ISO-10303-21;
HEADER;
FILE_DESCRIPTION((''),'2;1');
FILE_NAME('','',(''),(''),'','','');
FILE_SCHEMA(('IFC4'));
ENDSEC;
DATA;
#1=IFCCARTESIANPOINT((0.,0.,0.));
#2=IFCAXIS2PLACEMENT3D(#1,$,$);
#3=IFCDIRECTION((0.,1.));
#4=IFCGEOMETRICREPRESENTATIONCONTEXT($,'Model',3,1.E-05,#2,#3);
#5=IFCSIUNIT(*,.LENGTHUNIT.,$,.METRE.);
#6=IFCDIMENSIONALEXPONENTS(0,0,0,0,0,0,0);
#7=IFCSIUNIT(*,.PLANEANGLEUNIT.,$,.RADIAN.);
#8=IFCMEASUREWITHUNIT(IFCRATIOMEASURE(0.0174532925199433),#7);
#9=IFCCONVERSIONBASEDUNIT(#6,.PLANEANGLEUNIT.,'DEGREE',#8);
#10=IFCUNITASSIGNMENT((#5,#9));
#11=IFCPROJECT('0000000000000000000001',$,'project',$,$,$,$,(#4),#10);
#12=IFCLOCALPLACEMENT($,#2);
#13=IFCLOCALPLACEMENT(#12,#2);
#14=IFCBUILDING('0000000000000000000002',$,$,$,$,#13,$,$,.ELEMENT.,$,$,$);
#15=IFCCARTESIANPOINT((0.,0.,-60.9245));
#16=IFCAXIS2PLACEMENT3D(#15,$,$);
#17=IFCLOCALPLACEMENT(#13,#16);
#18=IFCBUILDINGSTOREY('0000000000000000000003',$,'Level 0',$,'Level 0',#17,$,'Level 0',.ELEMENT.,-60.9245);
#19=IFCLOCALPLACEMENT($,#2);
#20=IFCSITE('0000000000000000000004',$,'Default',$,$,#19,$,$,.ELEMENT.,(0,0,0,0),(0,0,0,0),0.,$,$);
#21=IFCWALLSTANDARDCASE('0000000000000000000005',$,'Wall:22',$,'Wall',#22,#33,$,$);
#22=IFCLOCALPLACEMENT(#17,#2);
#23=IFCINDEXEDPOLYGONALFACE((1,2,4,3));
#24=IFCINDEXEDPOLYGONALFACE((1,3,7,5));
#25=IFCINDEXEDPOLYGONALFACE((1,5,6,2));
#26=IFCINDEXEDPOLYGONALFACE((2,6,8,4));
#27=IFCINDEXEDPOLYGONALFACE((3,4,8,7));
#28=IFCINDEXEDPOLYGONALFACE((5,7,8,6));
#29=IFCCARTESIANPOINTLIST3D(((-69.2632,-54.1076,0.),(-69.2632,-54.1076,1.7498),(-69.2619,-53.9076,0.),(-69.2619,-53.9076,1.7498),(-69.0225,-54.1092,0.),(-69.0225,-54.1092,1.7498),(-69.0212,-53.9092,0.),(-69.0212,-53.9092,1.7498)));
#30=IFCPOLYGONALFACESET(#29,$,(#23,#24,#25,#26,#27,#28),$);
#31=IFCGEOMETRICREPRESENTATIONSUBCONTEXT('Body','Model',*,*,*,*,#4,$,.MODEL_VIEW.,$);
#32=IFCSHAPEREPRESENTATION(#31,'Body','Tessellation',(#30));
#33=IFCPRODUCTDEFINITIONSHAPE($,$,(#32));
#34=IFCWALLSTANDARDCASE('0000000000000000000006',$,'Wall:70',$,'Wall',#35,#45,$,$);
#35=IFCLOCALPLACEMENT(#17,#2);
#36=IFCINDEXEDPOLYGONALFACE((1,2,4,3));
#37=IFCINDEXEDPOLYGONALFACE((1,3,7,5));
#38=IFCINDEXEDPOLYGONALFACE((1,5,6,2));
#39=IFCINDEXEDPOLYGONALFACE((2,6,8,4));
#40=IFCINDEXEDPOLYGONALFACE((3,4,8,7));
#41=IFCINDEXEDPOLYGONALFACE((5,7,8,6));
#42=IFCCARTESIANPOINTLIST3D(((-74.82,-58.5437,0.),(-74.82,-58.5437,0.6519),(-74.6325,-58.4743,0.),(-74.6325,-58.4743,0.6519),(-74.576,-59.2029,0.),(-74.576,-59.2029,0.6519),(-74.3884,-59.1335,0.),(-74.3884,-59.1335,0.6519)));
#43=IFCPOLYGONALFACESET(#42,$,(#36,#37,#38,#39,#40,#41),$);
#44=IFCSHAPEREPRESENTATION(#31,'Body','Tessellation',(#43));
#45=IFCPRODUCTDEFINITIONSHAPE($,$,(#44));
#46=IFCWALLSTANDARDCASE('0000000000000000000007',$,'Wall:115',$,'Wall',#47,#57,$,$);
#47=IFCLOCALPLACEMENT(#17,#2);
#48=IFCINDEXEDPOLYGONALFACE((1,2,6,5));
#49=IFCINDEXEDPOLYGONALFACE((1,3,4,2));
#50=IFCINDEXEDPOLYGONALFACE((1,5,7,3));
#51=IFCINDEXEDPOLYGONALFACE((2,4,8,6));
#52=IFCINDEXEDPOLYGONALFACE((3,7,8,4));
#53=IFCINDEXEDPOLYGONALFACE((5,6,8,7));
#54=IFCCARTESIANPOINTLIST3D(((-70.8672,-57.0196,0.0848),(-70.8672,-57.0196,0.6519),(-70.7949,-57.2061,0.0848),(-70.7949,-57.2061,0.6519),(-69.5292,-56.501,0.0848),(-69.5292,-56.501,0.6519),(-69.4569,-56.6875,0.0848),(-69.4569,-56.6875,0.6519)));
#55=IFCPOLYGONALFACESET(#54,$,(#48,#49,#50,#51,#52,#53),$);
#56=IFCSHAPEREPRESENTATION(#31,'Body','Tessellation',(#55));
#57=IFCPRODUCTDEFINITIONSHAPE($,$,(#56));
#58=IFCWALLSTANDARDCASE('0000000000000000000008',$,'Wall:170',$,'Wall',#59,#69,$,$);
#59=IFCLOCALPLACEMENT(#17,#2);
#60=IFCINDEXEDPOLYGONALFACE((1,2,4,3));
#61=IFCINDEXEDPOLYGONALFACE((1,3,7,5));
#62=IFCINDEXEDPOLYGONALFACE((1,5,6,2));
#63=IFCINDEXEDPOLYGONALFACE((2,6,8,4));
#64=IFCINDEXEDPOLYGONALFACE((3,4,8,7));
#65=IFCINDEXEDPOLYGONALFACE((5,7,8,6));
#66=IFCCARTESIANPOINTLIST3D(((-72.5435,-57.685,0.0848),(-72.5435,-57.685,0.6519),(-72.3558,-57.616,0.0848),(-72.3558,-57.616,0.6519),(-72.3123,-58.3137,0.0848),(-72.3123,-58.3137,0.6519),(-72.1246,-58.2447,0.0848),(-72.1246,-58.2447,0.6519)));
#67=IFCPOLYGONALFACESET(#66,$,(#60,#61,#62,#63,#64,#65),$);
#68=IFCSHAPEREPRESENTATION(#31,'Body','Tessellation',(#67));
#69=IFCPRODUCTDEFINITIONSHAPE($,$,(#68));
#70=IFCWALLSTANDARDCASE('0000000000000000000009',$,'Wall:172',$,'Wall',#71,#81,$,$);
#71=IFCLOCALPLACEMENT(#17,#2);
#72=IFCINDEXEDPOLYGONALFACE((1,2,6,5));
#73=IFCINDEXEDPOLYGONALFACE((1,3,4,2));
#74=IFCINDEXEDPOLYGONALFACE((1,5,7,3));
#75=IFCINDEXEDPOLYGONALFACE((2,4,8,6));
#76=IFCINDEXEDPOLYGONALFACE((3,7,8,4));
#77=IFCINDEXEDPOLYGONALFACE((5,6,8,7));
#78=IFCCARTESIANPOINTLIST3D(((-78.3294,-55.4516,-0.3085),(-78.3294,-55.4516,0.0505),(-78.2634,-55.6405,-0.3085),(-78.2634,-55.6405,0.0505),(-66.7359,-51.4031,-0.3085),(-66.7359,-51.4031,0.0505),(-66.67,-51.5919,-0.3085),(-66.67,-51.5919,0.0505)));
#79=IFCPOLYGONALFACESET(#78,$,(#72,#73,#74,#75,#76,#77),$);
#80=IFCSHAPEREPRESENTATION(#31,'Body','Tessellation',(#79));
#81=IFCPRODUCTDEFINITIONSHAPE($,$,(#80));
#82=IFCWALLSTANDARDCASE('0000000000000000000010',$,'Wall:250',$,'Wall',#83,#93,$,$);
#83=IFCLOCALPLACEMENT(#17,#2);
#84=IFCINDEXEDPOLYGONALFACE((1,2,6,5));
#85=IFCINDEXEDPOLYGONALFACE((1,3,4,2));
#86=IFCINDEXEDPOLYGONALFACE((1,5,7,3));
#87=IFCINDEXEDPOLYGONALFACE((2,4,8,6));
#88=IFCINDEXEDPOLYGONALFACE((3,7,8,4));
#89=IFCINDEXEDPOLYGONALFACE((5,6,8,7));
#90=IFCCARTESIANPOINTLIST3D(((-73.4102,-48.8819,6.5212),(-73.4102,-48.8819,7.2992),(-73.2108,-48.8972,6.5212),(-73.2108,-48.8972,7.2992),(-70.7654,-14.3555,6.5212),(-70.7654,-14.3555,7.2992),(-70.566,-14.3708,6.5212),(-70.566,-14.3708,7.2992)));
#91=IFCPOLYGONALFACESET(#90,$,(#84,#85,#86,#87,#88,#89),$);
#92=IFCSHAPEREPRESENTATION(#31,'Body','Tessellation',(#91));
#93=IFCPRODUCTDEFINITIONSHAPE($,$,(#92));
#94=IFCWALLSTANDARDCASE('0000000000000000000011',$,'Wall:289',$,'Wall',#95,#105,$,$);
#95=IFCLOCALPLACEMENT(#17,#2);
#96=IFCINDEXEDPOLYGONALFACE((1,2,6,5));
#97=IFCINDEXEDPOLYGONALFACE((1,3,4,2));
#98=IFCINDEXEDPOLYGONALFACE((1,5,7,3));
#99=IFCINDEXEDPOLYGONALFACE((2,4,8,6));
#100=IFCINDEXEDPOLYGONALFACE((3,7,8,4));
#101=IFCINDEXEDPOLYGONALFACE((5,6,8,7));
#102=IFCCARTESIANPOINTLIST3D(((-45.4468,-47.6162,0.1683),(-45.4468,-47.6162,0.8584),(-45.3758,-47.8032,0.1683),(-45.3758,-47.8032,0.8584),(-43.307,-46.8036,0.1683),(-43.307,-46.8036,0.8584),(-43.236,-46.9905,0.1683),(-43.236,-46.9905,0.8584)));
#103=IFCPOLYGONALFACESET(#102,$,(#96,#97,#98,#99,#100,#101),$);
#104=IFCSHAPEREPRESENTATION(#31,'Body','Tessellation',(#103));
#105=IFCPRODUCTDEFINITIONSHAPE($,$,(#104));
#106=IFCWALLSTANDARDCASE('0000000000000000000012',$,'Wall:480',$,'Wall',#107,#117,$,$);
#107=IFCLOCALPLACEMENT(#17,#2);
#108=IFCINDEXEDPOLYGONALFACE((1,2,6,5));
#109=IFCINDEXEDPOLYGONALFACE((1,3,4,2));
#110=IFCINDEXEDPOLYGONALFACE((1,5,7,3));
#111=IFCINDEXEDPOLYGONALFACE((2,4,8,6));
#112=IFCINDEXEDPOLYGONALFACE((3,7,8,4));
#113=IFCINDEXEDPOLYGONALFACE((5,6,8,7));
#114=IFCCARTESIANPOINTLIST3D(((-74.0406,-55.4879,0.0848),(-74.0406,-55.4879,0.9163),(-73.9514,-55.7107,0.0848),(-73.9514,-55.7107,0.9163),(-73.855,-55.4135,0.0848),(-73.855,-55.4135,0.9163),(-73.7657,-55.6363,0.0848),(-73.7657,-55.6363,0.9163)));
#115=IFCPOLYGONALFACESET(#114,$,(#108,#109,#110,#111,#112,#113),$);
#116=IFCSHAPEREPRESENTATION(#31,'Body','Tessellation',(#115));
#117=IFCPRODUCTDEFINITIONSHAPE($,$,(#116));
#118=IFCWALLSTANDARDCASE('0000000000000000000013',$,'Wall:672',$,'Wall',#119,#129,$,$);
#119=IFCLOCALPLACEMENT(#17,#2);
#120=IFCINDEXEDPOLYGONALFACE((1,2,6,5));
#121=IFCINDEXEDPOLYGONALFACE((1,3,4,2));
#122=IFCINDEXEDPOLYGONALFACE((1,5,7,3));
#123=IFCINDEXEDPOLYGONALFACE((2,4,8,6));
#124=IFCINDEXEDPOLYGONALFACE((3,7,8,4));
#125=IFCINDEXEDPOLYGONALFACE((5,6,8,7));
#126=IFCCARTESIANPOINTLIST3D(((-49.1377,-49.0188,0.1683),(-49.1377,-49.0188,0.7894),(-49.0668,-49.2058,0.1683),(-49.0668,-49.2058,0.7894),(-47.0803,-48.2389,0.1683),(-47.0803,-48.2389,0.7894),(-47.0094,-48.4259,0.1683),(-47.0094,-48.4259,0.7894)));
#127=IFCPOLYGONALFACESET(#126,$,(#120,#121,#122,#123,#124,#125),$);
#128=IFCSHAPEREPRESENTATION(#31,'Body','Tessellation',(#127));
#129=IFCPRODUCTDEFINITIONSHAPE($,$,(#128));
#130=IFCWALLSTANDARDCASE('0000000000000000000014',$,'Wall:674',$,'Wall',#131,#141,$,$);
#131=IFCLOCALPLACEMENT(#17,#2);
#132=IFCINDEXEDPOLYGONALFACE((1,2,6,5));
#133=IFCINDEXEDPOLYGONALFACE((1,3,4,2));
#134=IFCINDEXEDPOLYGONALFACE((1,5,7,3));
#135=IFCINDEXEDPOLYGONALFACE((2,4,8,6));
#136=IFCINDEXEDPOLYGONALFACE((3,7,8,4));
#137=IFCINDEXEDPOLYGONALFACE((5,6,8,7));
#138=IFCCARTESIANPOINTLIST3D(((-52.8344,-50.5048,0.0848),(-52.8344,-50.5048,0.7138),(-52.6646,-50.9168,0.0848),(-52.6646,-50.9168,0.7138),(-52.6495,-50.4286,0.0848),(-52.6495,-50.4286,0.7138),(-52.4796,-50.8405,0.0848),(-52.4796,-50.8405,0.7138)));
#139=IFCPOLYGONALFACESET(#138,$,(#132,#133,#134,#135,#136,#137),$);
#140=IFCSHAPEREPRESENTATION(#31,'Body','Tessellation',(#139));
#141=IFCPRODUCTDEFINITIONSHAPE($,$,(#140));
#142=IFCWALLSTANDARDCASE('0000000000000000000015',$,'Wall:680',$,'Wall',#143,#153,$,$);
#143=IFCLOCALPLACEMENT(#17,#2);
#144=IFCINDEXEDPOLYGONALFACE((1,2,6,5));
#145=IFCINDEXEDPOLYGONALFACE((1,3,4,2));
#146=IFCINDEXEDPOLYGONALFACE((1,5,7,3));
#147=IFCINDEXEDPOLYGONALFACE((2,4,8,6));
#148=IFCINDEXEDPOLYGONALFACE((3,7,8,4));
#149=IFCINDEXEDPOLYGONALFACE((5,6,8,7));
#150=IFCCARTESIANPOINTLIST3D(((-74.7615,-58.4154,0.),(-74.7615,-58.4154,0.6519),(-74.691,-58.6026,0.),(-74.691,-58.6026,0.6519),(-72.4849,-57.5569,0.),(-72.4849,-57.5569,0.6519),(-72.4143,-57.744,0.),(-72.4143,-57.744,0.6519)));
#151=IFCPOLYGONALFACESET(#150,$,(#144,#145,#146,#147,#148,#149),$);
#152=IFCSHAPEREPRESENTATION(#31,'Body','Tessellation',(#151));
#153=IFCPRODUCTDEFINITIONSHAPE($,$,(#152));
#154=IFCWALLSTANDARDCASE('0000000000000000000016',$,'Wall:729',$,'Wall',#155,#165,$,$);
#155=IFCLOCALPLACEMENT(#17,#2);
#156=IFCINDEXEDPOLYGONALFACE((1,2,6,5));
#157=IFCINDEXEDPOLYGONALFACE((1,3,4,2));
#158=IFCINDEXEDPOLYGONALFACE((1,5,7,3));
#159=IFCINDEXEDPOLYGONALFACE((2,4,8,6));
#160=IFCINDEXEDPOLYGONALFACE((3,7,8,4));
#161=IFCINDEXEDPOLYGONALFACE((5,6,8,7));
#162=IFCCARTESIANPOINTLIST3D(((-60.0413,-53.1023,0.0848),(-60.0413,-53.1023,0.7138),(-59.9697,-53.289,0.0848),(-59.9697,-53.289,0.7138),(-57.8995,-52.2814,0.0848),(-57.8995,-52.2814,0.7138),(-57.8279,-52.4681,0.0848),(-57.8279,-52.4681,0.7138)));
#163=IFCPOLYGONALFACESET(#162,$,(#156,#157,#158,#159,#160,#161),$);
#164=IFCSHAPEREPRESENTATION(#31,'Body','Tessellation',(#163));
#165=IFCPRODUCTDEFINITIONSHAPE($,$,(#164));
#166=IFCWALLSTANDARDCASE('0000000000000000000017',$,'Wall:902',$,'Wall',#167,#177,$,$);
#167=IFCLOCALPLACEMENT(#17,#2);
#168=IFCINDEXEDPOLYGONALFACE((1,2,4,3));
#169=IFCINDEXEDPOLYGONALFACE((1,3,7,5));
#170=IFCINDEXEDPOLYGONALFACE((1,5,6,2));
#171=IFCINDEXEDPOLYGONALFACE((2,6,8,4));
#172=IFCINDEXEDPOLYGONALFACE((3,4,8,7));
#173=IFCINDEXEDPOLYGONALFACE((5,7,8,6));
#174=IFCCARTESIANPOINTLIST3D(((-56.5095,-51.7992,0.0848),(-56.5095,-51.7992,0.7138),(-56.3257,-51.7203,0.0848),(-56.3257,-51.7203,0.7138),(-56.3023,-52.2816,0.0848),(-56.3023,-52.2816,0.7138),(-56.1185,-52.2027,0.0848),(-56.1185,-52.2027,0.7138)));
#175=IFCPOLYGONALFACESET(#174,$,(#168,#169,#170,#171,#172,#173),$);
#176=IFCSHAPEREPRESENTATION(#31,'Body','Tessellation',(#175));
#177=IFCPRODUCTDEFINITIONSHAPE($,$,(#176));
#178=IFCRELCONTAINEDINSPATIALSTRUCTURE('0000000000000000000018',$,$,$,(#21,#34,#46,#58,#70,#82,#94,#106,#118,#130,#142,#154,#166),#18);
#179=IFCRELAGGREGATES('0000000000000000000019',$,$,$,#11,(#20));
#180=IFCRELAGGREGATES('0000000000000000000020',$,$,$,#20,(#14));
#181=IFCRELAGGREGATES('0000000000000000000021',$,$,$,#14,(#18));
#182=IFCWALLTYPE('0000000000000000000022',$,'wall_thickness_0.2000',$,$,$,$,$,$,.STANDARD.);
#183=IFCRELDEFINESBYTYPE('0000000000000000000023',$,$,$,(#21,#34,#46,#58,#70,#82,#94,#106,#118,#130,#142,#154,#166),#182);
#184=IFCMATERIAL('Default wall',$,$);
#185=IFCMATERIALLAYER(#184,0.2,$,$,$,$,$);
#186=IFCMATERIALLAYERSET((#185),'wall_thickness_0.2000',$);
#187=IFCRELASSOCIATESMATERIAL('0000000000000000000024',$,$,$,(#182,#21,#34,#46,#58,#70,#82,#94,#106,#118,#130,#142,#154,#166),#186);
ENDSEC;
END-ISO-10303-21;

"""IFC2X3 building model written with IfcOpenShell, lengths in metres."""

from ifc_helpers import new_model, entity, si_unit, converted_unit, direction, frame, origin, place, context, subcontext, project, spatial, polyline, outline, extrude, material, layer, layer_set, layer_usage, type_object, element, save


model = new_model("IFC2X3")

# Units and contexts
model_context = context("Model", 3, precision=1e-05, world=origin(), true_north=direction((0.0, 1.0)))
body_context = subcontext(model_context, "Body", "Model", "MODEL_VIEW")
ifc_project = project(units=[si_unit("LENGTHUNIT", "METRE"), converted_unit("PLANEANGLEUNIT", "DEGREE", entity("IfcRatioMeasure", 0.0174532925199433), si_unit("PLANEANGLEUNIT", "RADIAN"), dimensions=[0, 0, 0, 0, 0, 0, 0])], contexts=[model_context])

# Site, building, storey
site_placement = place(None, origin())
site = spatial("IfcSite", under=ifc_project, at=site_placement, Name="Default", CompositionType="ELEMENT", RefLatitude=(0, 0, 0, 0), RefLongitude=(0, 0, 0, 0), RefElevation=0.0)
placement_1 = place(None, origin())
building_placement = place(placement_1, origin())
building = spatial("IfcBuilding", under=site, at=building_placement, CompositionType="ELEMENT")
storey_placement = place(building_placement, frame((0.0, 0.0, -60.9245)))
storey = spatial("IfcBuildingStorey", under=building, at=storey_placement, Name="Level 0", ObjectType="Level 0", LongName="Level 0", CompositionType="ELEMENT", Elevation=-60.9245)

# Walls
ifc_material = material(Name="Default wall")
ifc_layer = layer(ifc_material, 0.2)
ifc_layer_set = layer_set([ifc_layer], Name="wall_thickness_0.2000")
ifc_layer_usage = layer_usage(ifc_layer_set, "AXIS2", "POSITIVE", -0.1)
wall_type = type_object("IfcWallType", Name="wall_thickness_0.2000", PredefinedType="STANDARD", material=ifc_layer_set)
wall_1_placement = place(storey_placement, frame((-69.0218, -54.0092, 0.0), z_axis=(0.0, 0.0, 1.0), x_axis=(-0.999978, 0.006609, 0.0)))
element("IfcWallStandardCase", 1, at=wall_1_placement, inside=storey, type_object=wall_type, material=ifc_layer_usage, Name="Wall:22", ObjectType="Wall", context=body_context, shape_type="SweptSolid", body=[
    extrude(outline(polyline([(0.2407, -0.1), (0.2407, 0.1), (0.0, 0.1), (0.0, -0.1), (0.2407, -0.1)])), origin(), (0.0, 0.0, 1.0), 1.7498),
])
wall_2_placement = place(storey_placement, frame((-74.4822, -59.1682, 0.0), z_axis=(0.0, 0.0, 1.0), x_axis=(-0.347236, 0.937778, 0.0)))
element("IfcWallStandardCase", 2, at=wall_2_placement, inside=storey, type_object=wall_type, material=ifc_layer_usage, Name="Wall:70", ObjectType="Wall", context=body_context, shape_type="SweptSolid", body=[
    extrude(outline(polyline([(0.7029, -0.1), (0.7029, 0.1), (0.0, 0.1), (0.0, -0.1), (0.7029, -0.1)])), origin(), (0.0, 0.0, 1.0), 0.6519),
])
placement_2 = place(building_placement, frame((0.0, 0.0, -60.8397)))
wall_3_placement = place(placement_2, frame((-70.8311, -57.1129, 0.0), z_axis=(0.0, 0.0, 1.0), x_axis=(0.93241, 0.361401, 0.0)))
element("IfcWallStandardCase", 3, at=wall_3_placement, inside=storey, type_object=wall_type, material=ifc_layer_usage, Name="Wall:115", ObjectType="Wall", context=body_context, shape_type="SweptSolid", body=[
    extrude(outline(polyline([(1.435, -0.1), (1.435, 0.1), (0.0, 0.1), (0.0, -0.1), (1.435, -0.1)])), origin(), (0.0, 0.0, 1.0), 0.5671),
])
placement_3 = place(building_placement, frame((0.0, 0.0, -60.8397)))
wall_4_placement = place(placement_3, frame((-72.2184, -58.2792, 0.0), z_axis=(0.0, 0.0, 1.0), x_axis=(-0.345126, 0.938556, 0.0)))
element("IfcWallStandardCase", 4, at=wall_4_placement, inside=storey, type_object=wall_type, material=ifc_layer_usage, Name="Wall:170", ObjectType="Wall", context=body_context, shape_type="SweptSolid", body=[
    extrude(outline(polyline([(0.6699, -0.1), (0.6699, 0.1), (0.0, 0.1), (0.0, -0.1), (0.6699, -0.1)])), origin(), (0.0, 0.0, 1.0), 0.5671),
])
placement_4 = place(building_placement, frame((0.0, 0.0, -61.233)))
wall_5_placement = place(placement_4, frame((-78.2964, -55.546, 0.0), z_axis=(0.0, 0.0, 1.0), x_axis=(0.94409, 0.329689, 0.0)))
element("IfcWallStandardCase", 5, at=wall_5_placement, inside=storey, type_object=wall_type, material=ifc_layer_usage, Name="Wall:172", ObjectType="Wall", context=body_context, shape_type="SweptSolid", body=[
    extrude(outline(polyline([(12.28, -0.1), (12.28, 0.1), (0.0, 0.1), (0.0, -0.1), (12.28, -0.1)])), origin(), (0.0, 0.0, 1.0), 0.359),
])
placement_5 = place(building_placement, frame((0.0, 0.0, -54.4033)))
wall_6_placement = place(placement_5, frame((-73.3105, -48.8895, 0.0), z_axis=(0.0, 0.0, 1.0), x_axis=(0.076377, 0.997079, 0.0)))
element("IfcWallStandardCase", 6, at=wall_6_placement, inside=storey, type_object=wall_type, material=ifc_layer_usage, Name="Wall:250", ObjectType="Wall", context=body_context, shape_type="SweptSolid", body=[
    extrude(outline(polyline([(34.6276, -0.1), (34.6276, 0.1), (0.0, 0.1), (0.0, -0.1), (34.6276, -0.1)])), origin(), (0.0, 0.0, 1.0), 0.778),
])
placement_6 = place(building_placement, frame((0.0, 0.0, -60.7562)))
wall_7_placement = place(placement_6, frame((-45.4113, -47.7097, 0.0), z_axis=(0.0, 0.0, 1.0), x_axis=(0.934854, 0.355031, 0.0)))
element("IfcWallStandardCase", 7, at=wall_7_placement, inside=storey, type_object=wall_type, material=ifc_layer_usage, Name="Wall:289", ObjectType="Wall", context=body_context, shape_type="SweptSolid", body=[
    extrude(outline(polyline([(2.2889, -0.1), (2.2889, 0.1), (0.0, 0.1), (0.0, -0.1), (2.2889, -0.1)])), origin(), (0.0, 0.0, 1.0), 0.69),
])
placement_7 = place(building_placement, frame((0.0, 0.0, -60.8397)))
wall_8_placement = place(placement_7, frame((-73.8586, -55.6735, 0.0), z_axis=(0.0, 0.0, 1.0), x_axis=(-0.3719, 0.928273, 0.0)))
element("IfcWallStandardCase", 8, at=wall_8_placement, inside=storey, type_object=wall_type, material=ifc_layer_usage, Name="Wall:480", ObjectType="Wall", context=body_context, shape_type="SweptSolid", body=[
    extrude(outline(polyline([(0.24, -0.1), (0.24, 0.1), (0.0, 0.1), (0.0, -0.1), (0.24, -0.1)])), origin(), (0.0, 0.0, 1.0), 0.8315),
])
placement_8 = place(building_placement, frame((0.0, 0.0, -60.7562)))
wall_9_placement = place(placement_8, frame((-49.1023, -49.1123, 0.0), z_axis=(0.0, 0.0, 1.0), x_axis=(0.935081, 0.354435, 0.0)))
element("IfcWallStandardCase", 9, at=wall_9_placement, inside=storey, type_object=wall_type, material=ifc_layer_usage, Name="Wall:672", ObjectType="Wall", context=body_context, shape_type="SweptSolid", body=[
    extrude(outline(polyline([(2.2003, -0.1), (2.2003, 0.1), (0.0, 0.1), (0.0, -0.1), (2.2003, -0.1)])), origin(), (0.0, 0.0, 1.0), 0.6211),
])
placement_9 = place(building_placement, frame((0.0, 0.0, -60.8397)))
wall_10_placement = place(placement_9, frame((-52.5721, -50.8786, 0.0), z_axis=(0.0, 0.0, 1.0), x_axis=(-0.381126, 0.924523, 0.0)))
element("IfcWallStandardCase", 10, at=wall_10_placement, inside=storey, type_object=wall_type, material=ifc_layer_usage, Name="Wall:674", ObjectType="Wall", context=body_context, shape_type="SweptSolid", body=[
    extrude(outline(polyline([(0.4456, -0.1), (0.4456, 0.1), (0.0, 0.1), (0.0, -0.1), (0.4456, -0.1)])), origin(), (0.0, 0.0, 1.0), 0.629),
])
wall_11_placement = place(storey_placement, frame((-74.7262, -58.509, 0.0), z_axis=(0.0, 0.0, 1.0), x_axis=(0.935678, 0.352854, 0.0)))
element("IfcWallStandardCase", 11, at=wall_11_placement, inside=storey, type_object=wall_type, material=ifc_layer_usage, Name="Wall:680", ObjectType="Wall", context=body_context, shape_type="SweptSolid", body=[
    extrude(outline(polyline([(2.4331, -0.1), (2.4331, 0.1), (0.0, 0.1), (0.0, -0.1), (2.4331, -0.1)])), origin(), (0.0, 0.0, 1.0), 0.6519),
])
placement_10 = place(building_placement, frame((0.0, 0.0, -60.8397)))
wall_12_placement = place(placement_10, frame((-60.0055, -53.1956, 0.0), z_axis=(0.0, 0.0, 1.0), x_axis=(0.933765, 0.357886, 0.0)))
element("IfcWallStandardCase", 12, at=wall_12_placement, inside=storey, type_object=wall_type, material=ifc_layer_usage, Name="Wall:729", ObjectType="Wall", context=body_context, shape_type="SweptSolid", body=[
    extrude(outline(polyline([(2.2937, -0.1), (2.2937, 0.1), (0.0, 0.1), (0.0, -0.1), (2.2937, -0.1)])), origin(), (0.0, 0.0, 1.0), 0.629),
])
placement_11 = place(building_placement, frame((0.0, 0.0, -60.8397)))
wall_13_placement = place(placement_11, frame((-56.2104, -52.2421, 0.0), z_axis=(0.0, 0.0, 1.0), x_axis=(-0.394709, 0.918806, 0.0)))
element("IfcWallStandardCase", 13, at=wall_13_placement, inside=storey, type_object=wall_type, material=ifc_layer_usage, Name="Wall:902", ObjectType="Wall", context=body_context, shape_type="SweptSolid", body=[
    extrude(outline(polyline([(0.525, -0.1), (0.525, 0.1), (0.0, 0.1), (0.0, -0.1), (0.525, -0.1)])), origin(), (0.0, 0.0, 1.0), 0.629),
])

save(model, "model.ifc")
